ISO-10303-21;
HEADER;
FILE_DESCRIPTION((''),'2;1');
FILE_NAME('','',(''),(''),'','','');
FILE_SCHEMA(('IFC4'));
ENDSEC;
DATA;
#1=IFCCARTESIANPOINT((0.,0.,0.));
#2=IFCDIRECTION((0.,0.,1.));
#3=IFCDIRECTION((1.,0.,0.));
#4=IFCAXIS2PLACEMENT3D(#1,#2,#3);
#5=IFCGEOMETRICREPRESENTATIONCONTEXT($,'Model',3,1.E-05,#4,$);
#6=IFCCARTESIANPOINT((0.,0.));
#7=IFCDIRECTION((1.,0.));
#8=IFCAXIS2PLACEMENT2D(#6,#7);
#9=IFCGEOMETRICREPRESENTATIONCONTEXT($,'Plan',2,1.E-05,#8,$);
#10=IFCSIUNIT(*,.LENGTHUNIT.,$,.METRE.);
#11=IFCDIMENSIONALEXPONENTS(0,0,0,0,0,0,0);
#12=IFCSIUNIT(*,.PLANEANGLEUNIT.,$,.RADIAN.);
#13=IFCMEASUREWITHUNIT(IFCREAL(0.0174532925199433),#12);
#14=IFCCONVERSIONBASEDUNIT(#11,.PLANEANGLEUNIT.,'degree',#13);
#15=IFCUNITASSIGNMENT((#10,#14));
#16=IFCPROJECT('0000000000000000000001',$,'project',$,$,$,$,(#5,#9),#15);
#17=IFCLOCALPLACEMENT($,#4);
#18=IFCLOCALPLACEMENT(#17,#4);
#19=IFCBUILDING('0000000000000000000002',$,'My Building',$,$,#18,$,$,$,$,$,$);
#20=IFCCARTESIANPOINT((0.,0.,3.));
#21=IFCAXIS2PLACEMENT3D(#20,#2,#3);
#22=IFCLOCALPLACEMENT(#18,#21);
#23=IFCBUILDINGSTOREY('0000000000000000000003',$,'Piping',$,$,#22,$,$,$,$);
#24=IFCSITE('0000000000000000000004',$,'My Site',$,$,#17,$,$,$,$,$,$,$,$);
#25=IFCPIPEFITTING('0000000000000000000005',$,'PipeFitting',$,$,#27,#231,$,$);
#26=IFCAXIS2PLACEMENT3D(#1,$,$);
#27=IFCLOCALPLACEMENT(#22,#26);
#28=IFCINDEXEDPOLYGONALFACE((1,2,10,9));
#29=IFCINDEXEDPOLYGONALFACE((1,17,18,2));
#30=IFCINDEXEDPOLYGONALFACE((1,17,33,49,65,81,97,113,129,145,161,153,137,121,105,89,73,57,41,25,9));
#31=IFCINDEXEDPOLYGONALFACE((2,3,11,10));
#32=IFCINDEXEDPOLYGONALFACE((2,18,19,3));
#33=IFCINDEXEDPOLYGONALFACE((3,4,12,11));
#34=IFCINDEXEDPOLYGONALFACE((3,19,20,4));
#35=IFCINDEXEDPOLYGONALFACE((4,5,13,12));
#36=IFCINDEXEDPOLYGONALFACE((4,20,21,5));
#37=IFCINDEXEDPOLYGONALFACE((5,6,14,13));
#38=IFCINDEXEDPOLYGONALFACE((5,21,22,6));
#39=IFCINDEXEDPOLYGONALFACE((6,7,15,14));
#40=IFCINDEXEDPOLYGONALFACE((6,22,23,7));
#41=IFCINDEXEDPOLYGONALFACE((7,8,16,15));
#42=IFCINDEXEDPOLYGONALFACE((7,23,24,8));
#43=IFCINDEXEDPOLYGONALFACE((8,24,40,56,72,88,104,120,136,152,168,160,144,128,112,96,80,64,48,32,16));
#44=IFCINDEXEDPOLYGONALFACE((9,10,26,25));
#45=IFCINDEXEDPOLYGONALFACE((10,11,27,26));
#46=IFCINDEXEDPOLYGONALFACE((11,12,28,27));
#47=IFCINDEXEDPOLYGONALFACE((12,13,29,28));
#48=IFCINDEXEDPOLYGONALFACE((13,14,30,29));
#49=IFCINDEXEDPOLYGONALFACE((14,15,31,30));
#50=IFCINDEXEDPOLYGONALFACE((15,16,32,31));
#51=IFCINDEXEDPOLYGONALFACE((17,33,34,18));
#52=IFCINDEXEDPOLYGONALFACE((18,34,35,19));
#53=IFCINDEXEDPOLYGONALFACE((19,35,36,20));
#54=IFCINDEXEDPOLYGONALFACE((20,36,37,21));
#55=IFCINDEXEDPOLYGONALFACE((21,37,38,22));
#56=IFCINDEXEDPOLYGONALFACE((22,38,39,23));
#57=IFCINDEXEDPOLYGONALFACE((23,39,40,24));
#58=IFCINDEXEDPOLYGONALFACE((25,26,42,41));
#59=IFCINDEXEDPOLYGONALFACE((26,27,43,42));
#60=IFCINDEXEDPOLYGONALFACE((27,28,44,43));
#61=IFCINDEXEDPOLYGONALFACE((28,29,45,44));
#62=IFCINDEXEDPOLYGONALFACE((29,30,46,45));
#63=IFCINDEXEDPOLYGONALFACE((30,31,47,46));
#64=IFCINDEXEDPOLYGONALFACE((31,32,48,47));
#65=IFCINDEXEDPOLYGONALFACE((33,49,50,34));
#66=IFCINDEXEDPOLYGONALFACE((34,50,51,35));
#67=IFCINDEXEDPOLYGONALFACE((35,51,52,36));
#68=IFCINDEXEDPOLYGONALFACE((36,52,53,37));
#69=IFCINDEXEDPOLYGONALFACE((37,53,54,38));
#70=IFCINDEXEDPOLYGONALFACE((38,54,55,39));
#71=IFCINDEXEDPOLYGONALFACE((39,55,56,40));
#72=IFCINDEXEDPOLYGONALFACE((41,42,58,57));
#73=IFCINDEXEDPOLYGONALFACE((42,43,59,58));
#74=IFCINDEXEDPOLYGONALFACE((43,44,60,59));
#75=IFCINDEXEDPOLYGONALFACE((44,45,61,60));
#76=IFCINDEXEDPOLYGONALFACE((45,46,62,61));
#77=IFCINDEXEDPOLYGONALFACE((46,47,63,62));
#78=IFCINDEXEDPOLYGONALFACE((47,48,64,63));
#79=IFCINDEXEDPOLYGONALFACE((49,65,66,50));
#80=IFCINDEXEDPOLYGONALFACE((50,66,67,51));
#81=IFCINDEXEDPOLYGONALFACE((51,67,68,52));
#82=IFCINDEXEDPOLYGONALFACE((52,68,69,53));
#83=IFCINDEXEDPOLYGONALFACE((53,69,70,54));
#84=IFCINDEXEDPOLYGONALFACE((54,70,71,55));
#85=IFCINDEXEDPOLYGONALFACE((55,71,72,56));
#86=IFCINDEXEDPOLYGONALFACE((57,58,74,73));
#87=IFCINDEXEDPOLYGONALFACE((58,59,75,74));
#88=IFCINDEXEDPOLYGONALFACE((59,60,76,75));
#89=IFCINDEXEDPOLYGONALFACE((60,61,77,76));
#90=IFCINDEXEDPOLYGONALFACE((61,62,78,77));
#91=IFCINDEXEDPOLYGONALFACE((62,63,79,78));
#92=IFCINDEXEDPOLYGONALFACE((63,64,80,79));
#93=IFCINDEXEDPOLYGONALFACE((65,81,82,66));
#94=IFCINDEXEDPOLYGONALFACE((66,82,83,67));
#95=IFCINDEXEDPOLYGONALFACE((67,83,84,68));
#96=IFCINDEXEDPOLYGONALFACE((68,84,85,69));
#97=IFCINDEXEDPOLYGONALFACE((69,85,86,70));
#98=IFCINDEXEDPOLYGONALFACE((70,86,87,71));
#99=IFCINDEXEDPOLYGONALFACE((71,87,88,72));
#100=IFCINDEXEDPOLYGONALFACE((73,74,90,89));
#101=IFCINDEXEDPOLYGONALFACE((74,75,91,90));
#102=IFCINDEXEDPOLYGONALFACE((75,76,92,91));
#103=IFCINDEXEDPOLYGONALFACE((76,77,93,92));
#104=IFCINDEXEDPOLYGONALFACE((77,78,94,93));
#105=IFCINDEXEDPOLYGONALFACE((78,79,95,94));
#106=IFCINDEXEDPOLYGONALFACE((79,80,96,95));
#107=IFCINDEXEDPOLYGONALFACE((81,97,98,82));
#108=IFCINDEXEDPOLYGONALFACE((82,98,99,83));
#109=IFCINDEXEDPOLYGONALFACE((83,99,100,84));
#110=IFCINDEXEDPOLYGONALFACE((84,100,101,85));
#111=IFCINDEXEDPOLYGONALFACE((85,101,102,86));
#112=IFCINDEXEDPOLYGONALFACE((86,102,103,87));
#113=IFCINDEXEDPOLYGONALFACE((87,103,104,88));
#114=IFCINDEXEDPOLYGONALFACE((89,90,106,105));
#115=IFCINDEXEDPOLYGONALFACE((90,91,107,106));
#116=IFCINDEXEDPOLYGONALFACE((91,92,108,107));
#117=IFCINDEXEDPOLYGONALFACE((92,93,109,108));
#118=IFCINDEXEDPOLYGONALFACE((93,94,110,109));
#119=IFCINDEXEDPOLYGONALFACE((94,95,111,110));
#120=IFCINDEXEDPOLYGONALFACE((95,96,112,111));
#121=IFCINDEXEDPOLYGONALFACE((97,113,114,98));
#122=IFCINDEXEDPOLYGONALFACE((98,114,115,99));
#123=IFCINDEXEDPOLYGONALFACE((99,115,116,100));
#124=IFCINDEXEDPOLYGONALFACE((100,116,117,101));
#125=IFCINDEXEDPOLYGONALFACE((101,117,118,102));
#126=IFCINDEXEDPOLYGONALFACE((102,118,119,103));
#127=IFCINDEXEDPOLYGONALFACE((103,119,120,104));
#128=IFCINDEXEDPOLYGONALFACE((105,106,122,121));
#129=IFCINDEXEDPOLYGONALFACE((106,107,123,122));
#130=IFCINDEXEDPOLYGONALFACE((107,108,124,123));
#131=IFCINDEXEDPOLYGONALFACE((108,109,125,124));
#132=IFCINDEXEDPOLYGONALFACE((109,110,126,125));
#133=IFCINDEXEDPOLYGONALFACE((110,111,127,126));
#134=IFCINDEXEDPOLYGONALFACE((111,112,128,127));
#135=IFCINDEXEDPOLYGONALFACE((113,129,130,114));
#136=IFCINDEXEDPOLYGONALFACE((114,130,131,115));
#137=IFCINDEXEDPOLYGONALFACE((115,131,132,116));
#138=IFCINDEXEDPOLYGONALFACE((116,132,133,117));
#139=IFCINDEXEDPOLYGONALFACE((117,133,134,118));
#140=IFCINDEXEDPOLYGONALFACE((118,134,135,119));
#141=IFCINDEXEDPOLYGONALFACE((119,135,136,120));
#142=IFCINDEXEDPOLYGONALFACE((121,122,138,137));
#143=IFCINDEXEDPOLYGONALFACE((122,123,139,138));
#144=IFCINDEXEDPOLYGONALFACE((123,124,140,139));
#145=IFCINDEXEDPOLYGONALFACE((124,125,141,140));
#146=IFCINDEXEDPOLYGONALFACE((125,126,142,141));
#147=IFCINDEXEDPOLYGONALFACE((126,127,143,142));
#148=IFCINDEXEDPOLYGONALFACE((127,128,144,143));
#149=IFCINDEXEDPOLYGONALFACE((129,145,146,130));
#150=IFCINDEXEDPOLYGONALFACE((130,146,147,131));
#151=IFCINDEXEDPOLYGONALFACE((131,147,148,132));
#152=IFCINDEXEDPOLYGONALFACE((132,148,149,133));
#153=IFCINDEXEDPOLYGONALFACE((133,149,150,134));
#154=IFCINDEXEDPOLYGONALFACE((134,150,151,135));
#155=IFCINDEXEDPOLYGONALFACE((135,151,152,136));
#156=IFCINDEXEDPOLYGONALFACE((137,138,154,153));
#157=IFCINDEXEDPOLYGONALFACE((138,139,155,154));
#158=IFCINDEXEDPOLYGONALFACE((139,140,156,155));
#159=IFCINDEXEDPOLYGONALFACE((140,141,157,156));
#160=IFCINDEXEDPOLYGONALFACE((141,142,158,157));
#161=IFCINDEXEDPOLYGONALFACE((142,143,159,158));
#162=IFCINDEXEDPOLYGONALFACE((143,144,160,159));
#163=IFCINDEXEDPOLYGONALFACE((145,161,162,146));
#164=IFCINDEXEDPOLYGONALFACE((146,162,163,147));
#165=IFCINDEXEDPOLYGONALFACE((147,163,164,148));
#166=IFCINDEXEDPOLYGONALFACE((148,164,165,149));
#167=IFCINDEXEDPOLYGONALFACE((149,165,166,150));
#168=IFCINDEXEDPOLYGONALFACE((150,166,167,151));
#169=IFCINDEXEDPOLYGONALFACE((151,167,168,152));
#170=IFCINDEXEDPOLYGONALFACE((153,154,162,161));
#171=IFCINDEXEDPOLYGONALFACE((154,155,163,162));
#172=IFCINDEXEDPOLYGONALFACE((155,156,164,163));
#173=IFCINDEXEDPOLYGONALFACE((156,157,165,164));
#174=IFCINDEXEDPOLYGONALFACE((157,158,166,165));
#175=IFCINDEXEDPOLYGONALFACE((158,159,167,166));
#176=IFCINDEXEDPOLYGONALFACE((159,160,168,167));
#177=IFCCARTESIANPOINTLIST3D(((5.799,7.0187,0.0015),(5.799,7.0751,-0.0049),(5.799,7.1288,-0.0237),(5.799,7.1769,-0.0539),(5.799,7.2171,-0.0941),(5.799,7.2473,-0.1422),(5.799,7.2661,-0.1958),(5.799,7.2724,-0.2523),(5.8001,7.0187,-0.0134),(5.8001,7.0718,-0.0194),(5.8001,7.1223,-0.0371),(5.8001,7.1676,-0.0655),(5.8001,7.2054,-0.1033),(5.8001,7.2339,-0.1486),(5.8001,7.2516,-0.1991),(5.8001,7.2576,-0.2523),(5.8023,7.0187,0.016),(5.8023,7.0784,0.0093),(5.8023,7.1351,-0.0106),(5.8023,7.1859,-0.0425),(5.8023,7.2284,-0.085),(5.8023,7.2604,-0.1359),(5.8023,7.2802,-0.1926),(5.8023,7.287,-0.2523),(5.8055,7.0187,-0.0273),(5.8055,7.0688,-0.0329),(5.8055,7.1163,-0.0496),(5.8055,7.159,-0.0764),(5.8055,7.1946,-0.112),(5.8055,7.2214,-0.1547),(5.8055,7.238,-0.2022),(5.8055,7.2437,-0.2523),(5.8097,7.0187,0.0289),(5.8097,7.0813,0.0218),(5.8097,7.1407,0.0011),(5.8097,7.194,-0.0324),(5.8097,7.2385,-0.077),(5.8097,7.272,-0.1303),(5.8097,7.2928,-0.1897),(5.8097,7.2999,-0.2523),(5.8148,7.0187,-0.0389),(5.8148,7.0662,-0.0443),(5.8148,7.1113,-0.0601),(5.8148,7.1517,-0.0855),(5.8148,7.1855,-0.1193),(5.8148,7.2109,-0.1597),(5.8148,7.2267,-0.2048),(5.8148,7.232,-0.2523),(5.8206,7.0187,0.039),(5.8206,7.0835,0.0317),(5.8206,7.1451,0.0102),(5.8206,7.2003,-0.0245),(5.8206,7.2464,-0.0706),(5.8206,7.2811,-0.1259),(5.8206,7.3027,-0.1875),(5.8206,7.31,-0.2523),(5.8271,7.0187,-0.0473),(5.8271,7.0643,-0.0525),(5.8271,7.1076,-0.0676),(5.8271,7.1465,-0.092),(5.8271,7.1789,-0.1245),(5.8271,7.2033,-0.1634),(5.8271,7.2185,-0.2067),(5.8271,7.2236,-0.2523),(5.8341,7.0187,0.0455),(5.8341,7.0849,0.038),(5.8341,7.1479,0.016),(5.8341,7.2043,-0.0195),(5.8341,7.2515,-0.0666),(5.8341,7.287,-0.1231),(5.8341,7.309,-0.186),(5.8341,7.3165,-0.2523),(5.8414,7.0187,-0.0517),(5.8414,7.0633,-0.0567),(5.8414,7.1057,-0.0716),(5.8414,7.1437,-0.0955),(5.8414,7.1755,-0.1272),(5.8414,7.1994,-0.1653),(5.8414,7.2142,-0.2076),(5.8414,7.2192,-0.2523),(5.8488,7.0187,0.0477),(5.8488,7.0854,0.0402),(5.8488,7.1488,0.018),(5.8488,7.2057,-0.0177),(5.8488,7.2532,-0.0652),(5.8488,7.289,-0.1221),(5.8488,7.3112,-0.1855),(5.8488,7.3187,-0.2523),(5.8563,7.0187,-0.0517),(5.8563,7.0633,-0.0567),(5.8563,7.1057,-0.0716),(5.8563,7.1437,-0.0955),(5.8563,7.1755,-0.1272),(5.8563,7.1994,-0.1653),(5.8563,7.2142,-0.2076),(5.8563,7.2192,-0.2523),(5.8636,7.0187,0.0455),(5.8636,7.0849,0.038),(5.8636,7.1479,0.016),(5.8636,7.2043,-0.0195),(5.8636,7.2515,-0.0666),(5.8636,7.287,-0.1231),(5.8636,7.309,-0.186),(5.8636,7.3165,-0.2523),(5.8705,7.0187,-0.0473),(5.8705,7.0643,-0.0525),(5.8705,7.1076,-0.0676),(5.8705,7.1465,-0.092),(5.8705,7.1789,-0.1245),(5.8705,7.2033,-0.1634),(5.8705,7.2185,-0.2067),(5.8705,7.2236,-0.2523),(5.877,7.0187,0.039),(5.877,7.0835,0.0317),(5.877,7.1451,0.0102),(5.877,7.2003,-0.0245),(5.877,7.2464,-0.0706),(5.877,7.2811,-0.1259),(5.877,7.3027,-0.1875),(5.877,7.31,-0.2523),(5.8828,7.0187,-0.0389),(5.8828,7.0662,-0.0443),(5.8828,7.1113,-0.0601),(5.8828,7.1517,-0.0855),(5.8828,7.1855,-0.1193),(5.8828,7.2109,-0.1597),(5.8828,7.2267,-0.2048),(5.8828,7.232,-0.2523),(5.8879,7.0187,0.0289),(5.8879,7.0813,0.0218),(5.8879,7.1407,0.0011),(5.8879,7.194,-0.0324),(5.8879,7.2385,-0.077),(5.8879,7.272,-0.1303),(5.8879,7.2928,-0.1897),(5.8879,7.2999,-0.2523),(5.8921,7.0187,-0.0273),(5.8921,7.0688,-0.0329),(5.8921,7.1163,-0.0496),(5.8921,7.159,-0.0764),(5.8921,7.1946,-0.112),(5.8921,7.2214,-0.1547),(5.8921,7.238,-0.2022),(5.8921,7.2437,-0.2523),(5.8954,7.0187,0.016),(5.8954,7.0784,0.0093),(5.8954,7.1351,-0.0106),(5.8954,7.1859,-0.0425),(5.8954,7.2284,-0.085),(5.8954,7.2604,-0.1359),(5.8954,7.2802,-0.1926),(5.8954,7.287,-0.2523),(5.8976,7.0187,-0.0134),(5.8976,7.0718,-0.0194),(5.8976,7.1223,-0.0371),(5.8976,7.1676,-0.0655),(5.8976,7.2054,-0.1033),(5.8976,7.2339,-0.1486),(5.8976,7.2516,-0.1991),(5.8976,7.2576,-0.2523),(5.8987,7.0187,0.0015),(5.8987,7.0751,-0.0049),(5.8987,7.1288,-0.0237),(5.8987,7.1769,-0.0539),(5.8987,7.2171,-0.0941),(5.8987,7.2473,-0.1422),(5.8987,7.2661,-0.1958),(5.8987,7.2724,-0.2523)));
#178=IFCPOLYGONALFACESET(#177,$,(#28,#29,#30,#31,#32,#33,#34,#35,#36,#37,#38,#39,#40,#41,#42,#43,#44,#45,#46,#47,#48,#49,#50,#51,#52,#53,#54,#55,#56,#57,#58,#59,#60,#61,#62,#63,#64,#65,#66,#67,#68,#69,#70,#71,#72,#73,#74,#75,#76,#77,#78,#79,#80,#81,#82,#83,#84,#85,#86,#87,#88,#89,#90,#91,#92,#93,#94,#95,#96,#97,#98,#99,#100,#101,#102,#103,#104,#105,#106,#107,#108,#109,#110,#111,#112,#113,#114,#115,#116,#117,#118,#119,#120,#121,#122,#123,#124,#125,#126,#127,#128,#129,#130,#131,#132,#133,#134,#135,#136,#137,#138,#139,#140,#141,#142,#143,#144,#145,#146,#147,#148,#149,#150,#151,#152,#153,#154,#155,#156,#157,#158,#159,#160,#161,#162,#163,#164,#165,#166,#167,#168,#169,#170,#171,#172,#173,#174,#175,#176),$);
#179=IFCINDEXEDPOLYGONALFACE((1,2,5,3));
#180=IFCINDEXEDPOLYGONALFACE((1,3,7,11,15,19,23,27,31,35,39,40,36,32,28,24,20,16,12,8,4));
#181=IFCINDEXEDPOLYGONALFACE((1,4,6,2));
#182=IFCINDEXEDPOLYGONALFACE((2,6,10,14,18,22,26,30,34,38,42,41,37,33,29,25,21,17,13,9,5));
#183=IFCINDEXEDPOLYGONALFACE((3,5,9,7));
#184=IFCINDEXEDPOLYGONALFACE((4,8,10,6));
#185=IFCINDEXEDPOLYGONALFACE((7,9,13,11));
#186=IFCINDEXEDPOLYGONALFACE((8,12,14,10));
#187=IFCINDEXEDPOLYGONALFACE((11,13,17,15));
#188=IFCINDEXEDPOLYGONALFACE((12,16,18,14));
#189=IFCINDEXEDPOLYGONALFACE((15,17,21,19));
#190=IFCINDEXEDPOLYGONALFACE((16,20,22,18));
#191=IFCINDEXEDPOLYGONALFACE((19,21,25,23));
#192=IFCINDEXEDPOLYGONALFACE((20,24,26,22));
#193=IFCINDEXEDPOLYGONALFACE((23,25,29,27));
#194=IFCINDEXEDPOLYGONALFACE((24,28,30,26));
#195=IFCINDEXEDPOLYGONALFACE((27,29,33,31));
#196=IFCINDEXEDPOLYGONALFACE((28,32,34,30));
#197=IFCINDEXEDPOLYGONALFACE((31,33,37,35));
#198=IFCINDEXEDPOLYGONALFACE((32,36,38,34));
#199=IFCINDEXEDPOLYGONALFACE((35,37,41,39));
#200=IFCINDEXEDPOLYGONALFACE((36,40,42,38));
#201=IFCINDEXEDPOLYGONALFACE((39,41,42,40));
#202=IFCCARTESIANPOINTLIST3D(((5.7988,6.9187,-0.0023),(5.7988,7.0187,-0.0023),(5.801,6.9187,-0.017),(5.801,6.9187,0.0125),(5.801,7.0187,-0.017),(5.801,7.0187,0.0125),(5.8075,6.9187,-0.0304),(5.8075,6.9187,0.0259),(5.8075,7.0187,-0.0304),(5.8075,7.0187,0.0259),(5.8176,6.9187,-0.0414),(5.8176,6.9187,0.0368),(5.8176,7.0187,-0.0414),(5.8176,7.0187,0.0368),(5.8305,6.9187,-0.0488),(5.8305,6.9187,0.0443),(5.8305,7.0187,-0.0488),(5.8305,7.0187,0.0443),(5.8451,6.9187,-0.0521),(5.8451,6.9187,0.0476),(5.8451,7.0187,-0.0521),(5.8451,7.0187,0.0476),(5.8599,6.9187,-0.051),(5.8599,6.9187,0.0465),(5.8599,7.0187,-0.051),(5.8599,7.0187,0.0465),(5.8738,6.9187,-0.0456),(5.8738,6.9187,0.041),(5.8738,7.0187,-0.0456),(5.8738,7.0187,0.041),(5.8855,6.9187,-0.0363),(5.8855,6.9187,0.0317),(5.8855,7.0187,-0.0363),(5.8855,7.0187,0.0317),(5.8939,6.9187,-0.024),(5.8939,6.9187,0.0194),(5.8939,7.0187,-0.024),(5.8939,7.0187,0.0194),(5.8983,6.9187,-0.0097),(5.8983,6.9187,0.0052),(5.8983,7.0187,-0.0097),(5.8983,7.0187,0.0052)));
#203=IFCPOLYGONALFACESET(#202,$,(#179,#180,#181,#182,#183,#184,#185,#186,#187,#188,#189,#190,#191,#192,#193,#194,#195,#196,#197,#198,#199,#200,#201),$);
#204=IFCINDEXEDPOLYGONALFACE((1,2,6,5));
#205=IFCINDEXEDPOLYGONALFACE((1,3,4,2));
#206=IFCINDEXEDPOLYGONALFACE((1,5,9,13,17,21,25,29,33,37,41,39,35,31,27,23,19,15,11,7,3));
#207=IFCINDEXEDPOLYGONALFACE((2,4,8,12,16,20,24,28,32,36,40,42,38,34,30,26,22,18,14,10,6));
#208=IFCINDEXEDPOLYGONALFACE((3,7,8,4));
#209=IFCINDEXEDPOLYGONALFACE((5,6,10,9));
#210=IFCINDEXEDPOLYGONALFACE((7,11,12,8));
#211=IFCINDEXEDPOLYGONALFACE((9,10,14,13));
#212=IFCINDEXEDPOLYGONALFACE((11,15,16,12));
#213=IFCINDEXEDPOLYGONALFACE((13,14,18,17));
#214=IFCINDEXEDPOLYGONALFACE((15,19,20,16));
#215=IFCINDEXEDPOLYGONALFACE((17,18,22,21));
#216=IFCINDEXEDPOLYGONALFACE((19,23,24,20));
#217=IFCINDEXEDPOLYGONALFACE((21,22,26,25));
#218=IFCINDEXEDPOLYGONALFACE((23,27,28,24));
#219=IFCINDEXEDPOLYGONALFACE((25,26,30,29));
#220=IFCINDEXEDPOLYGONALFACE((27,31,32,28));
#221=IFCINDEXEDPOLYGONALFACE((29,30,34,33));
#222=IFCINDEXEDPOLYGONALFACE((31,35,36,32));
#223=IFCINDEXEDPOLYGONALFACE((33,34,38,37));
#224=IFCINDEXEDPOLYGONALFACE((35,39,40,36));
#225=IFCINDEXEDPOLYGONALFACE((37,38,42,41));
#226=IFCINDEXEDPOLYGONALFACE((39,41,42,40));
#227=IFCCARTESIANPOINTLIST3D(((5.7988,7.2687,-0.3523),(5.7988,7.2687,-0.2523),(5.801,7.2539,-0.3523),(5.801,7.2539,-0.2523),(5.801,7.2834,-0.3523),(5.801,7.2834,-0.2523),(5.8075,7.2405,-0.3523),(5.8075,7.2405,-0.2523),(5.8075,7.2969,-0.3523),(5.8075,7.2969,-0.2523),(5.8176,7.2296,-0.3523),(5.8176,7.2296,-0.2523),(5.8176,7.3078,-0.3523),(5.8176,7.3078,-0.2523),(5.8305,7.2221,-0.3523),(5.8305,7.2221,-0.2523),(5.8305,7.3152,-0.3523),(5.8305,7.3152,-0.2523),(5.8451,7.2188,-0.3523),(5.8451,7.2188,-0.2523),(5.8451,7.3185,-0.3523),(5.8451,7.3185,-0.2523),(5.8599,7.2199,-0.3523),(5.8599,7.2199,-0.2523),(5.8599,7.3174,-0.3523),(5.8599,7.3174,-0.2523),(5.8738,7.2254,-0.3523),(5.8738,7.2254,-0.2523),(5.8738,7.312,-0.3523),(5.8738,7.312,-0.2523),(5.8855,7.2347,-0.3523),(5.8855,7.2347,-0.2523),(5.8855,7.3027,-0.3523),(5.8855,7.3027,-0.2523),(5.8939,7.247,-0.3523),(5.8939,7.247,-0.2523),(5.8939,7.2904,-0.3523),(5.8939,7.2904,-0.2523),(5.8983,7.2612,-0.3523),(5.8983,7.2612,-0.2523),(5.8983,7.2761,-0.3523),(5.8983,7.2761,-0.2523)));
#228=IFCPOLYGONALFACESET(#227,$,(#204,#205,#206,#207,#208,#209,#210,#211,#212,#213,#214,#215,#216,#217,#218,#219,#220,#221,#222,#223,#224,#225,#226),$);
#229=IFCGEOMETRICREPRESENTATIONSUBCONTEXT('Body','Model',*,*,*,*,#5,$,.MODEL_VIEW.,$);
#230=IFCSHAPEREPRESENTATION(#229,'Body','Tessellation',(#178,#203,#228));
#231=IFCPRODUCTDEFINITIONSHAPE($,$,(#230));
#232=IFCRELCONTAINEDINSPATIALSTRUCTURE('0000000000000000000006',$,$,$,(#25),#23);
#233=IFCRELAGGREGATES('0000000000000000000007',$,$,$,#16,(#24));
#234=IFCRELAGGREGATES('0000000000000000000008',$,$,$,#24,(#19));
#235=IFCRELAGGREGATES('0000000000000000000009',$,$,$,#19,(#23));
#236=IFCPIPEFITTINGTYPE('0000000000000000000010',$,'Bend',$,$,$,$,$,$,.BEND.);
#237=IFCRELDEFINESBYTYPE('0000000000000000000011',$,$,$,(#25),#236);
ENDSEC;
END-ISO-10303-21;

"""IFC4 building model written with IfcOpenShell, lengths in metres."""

from ifc_helpers import new_model, entity, si_unit, converted_unit, frame, origin_with_axes, origin_2d_with_axis, place, context, subcontext, project, spatial, circle, extrude, source, transform, mapped, type_object, type_shapes, element, save


model = new_model("IFC4")

# Units and contexts
model_context = context("Model", 3, precision=1e-05, world=origin_with_axes())
plan_context = context("Plan", 2, precision=1e-05, world=origin_2d_with_axis())
body_context = subcontext(model_context, "Body", "Model", "MODEL_VIEW")
ifc_project = project(units=[si_unit("LENGTHUNIT", "METRE"), converted_unit("PLANEANGLEUNIT", "degree", entity("IfcReal", 0.0174532925199433), si_unit("PLANEANGLEUNIT", "RADIAN"), dimensions=[0, 0, 0, 0, 0, 0, 0])], contexts=[model_context, plan_context])

# Site, building, storey
site_placement = place(None, origin_with_axes())
site = spatial("IfcSite", under=ifc_project, at=site_placement, Name="My Site")
building_placement = place(site_placement, origin_with_axes())
building = spatial("IfcBuilding", under=site, at=building_placement, Name="My Building")
storey_placement = place(building_placement, frame((0.0, 0.0, 3.0), z_axis=(0.0, 0.0, 1.0), x_axis=(1.0, 0.0, 0.0)))
storey = spatial("IfcBuildingStorey", under=building, at=storey_placement, Name="Piping")

# Pipe fitting
pipe_fitting_type_1 = type_object("IfcPipeFittingType", Name="Bend", PredefinedType="BEND")
shared_shape = source(origin_with_axes(), body_context, "Body", "SolidModel", [
    entity("IfcSweptDiskSolid", entity("IfcIndexedPolyCurve", entity("IfcCartesianPointList3D", [[0.0, 0.0, -0.1], [0.0, 0.0732, -0.2768], [0.0, 0.25, -0.35]]), [entity("IfcArcIndex", [1, 2, 3])]), 0.05),
    extrude(circle(Radius=0.05), origin_with_axes(), (0.0, 0.0, -1.0), 0.1),
    extrude(circle(Radius=0.05), frame((0.0, 0.25, -0.35), z_axis=(0.0, 1.0, 0.0), x_axis=(1.0, 0.0, 0.0)), (0.0, 0.0, 1.0), 0.1),
])
type_shapes(pipe_fitting_type_1, [shared_shape])
for number, where, z_axis, x_axis, name in (
    (1, (5.8488, 6.9187, -0.0023), (0.0, -1.0, 0.0), (-1.0, 0.0, 0.0), "PipeFitting"),
):
    element("IfcPipeFitting", number, at=place(storey_placement, frame(where, z_axis=z_axis, x_axis=x_axis)), inside=storey, type_object=pipe_fitting_type_1, Name=name, context=body_context, shape_type="MappedRepresentation", body=[
        mapped(shared_shape, transform((0.0, 0.0, 0.0), x_axis=(1.0, 0.0, 0.0), y_axis=(0.0, 1.0, 0.0), z_axis=(0.0, 0.0, 1.0), scale=1.0)),
    ])

save(model, "model.ifc")
